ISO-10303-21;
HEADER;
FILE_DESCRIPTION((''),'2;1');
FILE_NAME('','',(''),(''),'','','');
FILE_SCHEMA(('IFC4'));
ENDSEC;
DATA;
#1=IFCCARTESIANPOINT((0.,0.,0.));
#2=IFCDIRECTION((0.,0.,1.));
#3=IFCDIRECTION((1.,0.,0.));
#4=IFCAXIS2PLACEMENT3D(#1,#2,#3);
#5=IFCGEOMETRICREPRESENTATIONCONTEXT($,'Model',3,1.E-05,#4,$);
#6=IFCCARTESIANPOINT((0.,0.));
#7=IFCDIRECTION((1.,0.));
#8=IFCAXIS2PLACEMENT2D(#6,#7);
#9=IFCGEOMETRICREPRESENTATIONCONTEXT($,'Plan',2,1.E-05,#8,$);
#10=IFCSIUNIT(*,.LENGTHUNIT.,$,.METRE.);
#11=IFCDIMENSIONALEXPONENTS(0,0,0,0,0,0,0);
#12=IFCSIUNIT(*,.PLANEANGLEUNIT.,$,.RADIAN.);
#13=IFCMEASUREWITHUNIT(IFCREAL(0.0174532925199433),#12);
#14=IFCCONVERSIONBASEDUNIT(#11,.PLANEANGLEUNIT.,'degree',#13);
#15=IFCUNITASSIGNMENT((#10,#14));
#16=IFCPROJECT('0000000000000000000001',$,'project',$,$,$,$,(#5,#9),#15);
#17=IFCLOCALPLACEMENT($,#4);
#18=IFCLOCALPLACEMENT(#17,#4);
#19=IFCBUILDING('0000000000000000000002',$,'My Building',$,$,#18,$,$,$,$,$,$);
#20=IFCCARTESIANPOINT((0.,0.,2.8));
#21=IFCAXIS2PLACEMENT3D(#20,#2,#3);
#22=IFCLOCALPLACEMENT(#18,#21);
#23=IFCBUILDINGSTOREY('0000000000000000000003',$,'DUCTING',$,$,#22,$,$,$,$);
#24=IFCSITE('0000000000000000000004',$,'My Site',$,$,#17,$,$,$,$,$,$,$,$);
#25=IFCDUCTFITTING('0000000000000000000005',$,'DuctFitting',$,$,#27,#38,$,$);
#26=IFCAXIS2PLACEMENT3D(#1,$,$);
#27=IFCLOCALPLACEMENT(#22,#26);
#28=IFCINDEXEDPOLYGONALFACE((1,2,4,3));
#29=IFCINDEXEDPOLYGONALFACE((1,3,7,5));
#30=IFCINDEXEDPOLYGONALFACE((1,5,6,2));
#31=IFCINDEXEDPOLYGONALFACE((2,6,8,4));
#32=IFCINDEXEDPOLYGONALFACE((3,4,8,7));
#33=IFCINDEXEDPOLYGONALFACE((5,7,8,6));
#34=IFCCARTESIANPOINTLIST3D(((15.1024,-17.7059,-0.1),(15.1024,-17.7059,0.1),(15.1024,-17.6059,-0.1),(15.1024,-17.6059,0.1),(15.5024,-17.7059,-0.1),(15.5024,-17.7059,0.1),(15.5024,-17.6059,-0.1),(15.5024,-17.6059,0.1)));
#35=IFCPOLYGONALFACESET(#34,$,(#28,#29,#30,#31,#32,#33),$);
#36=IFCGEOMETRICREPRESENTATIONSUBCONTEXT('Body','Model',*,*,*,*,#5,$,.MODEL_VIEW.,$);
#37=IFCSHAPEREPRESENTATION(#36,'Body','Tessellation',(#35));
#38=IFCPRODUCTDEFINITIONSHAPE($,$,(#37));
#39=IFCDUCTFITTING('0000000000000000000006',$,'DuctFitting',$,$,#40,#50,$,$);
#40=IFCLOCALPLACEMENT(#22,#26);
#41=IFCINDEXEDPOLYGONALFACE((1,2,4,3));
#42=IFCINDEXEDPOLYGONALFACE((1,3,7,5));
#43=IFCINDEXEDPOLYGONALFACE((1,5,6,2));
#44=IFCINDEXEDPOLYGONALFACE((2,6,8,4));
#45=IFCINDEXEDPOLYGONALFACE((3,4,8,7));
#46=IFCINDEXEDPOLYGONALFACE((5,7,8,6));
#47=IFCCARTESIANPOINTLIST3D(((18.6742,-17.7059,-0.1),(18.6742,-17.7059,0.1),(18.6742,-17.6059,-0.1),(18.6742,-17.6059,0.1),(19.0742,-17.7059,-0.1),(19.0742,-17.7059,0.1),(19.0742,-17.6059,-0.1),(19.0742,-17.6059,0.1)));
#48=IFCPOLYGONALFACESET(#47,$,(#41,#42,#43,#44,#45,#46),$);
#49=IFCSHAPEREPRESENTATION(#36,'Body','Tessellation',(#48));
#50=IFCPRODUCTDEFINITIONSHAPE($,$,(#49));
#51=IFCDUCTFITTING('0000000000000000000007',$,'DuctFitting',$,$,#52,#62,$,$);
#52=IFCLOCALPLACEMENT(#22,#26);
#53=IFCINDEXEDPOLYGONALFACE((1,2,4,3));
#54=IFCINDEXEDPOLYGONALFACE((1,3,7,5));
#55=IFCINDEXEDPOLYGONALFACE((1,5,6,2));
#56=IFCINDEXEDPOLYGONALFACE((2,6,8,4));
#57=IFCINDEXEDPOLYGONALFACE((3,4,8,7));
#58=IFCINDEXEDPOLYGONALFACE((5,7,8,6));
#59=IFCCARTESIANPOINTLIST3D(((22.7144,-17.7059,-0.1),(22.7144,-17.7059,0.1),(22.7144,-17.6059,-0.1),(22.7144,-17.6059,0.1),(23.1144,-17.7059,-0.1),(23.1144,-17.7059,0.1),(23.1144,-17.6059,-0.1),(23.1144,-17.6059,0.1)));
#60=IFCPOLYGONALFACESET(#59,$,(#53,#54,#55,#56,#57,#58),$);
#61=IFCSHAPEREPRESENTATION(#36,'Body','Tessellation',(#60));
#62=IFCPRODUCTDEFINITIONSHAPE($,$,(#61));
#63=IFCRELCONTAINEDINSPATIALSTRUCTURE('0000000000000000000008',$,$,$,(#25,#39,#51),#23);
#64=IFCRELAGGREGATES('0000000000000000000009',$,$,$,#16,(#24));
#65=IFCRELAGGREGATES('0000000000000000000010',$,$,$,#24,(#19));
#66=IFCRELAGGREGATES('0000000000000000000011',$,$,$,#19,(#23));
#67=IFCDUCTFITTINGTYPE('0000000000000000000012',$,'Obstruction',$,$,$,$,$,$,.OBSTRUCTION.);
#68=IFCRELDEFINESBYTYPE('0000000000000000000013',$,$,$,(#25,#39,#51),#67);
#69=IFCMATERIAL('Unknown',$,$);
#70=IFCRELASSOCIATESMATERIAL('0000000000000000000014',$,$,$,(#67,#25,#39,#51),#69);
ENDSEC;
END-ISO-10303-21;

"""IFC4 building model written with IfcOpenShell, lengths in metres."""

from ifc_helpers import new_model, entity, si_unit, converted_unit, frame, origin_with_axes, origin_2d_with_axis, place, context, subcontext, project, spatial, rectangle, extrude, material, material_profile, profile_set, profile_usage, type_object, element, save


model = new_model("IFC4")

# Units and contexts
model_context = context("Model", 3, precision=1e-05, world=origin_with_axes())
plan_context = context("Plan", 2, precision=1e-05, world=origin_2d_with_axis())
body_context = subcontext(model_context, "Body", "Model", "MODEL_VIEW")
ifc_project = project(units=[si_unit("LENGTHUNIT", "METRE"), converted_unit("PLANEANGLEUNIT", "degree", entity("IfcReal", 0.0174532925199433), si_unit("PLANEANGLEUNIT", "RADIAN"), dimensions=[0, 0, 0, 0, 0, 0, 0])], contexts=[model_context, plan_context])

# Site, building, storey
site_placement = place(None, origin_with_axes())
site = spatial("IfcSite", under=ifc_project, at=site_placement, Name="My Site")
building_placement = place(site_placement, origin_with_axes())
building = spatial("IfcBuilding", under=site, at=building_placement, Name="My Building")
storey_placement = place(building_placement, frame((0.0, 0.0, 2.8), z_axis=(0.0, 0.0, 1.0), x_axis=(1.0, 0.0, 0.0)))
storey = spatial("IfcBuildingStorey", under=building, at=storey_placement, Name="DUCTING")

# Shared definitions
ifc_material = material(Name="Unknown")

# Duct fittings
ifc_material_profile_1 = material_profile(ifc_material, rectangle(XDim=0.4, YDim=0.2))
ifc_profile_set_1 = profile_set([ifc_material_profile_1])
duct_fitting_type_1 = type_object("IfcDuctFittingType", Name="Obstruction", PredefinedType="OBSTRUCTION", material=ifc_profile_set_1)
ifc_profile_usage_1 = profile_usage(ifc_profile_set_1, cardinal=5)
duct_fitting_1_placement = place(storey_placement, frame((15.3024, -17.6059, 0.0), z_axis=(0.0, -1.0, 0.0), x_axis=(-1.0, 0.0, 0.0)))
element("IfcDuctFitting", 1, at=duct_fitting_1_placement, inside=storey, type_object=duct_fitting_type_1, material=ifc_profile_usage_1, Name="DuctFitting", context=body_context, shape_type="SweptSolid", body=[
    extrude(rectangle(XDim=0.4, YDim=0.2), origin_with_axes(), (0.0, 0.0, 1.0), 0.1),
])
ifc_profile_usage_2 = profile_usage(ifc_profile_set_1, cardinal=5)
duct_fitting_2_placement = place(storey_placement, frame((18.8742, -17.6059, 0.0), z_axis=(0.0, -1.0, 0.0), x_axis=(-1.0, 0.0, 0.0)))
element("IfcDuctFitting", 2, at=duct_fitting_2_placement, inside=storey, type_object=duct_fitting_type_1, material=ifc_profile_usage_2, Name="DuctFitting", context=body_context, shape_type="SweptSolid", body=[
    extrude(rectangle(XDim=0.4, YDim=0.2), origin_with_axes(), (0.0, 0.0, 1.0), 0.1),
])
ifc_profile_usage_3 = profile_usage(ifc_profile_set_1, cardinal=5)
duct_fitting_3_placement = place(storey_placement, frame((22.9144, -17.6059, 0.0), z_axis=(0.0, -1.0, 0.0), x_axis=(-1.0, 0.0, 0.0)))
element("IfcDuctFitting", 3, at=duct_fitting_3_placement, inside=storey, type_object=duct_fitting_type_1, material=ifc_profile_usage_3, Name="DuctFitting", context=body_context, shape_type="SweptSolid", body=[
    extrude(rectangle(XDim=0.4, YDim=0.2), origin_with_axes(), (0.0, 0.0, 1.0), 0.1),
])

save(model, "model.ifc")
